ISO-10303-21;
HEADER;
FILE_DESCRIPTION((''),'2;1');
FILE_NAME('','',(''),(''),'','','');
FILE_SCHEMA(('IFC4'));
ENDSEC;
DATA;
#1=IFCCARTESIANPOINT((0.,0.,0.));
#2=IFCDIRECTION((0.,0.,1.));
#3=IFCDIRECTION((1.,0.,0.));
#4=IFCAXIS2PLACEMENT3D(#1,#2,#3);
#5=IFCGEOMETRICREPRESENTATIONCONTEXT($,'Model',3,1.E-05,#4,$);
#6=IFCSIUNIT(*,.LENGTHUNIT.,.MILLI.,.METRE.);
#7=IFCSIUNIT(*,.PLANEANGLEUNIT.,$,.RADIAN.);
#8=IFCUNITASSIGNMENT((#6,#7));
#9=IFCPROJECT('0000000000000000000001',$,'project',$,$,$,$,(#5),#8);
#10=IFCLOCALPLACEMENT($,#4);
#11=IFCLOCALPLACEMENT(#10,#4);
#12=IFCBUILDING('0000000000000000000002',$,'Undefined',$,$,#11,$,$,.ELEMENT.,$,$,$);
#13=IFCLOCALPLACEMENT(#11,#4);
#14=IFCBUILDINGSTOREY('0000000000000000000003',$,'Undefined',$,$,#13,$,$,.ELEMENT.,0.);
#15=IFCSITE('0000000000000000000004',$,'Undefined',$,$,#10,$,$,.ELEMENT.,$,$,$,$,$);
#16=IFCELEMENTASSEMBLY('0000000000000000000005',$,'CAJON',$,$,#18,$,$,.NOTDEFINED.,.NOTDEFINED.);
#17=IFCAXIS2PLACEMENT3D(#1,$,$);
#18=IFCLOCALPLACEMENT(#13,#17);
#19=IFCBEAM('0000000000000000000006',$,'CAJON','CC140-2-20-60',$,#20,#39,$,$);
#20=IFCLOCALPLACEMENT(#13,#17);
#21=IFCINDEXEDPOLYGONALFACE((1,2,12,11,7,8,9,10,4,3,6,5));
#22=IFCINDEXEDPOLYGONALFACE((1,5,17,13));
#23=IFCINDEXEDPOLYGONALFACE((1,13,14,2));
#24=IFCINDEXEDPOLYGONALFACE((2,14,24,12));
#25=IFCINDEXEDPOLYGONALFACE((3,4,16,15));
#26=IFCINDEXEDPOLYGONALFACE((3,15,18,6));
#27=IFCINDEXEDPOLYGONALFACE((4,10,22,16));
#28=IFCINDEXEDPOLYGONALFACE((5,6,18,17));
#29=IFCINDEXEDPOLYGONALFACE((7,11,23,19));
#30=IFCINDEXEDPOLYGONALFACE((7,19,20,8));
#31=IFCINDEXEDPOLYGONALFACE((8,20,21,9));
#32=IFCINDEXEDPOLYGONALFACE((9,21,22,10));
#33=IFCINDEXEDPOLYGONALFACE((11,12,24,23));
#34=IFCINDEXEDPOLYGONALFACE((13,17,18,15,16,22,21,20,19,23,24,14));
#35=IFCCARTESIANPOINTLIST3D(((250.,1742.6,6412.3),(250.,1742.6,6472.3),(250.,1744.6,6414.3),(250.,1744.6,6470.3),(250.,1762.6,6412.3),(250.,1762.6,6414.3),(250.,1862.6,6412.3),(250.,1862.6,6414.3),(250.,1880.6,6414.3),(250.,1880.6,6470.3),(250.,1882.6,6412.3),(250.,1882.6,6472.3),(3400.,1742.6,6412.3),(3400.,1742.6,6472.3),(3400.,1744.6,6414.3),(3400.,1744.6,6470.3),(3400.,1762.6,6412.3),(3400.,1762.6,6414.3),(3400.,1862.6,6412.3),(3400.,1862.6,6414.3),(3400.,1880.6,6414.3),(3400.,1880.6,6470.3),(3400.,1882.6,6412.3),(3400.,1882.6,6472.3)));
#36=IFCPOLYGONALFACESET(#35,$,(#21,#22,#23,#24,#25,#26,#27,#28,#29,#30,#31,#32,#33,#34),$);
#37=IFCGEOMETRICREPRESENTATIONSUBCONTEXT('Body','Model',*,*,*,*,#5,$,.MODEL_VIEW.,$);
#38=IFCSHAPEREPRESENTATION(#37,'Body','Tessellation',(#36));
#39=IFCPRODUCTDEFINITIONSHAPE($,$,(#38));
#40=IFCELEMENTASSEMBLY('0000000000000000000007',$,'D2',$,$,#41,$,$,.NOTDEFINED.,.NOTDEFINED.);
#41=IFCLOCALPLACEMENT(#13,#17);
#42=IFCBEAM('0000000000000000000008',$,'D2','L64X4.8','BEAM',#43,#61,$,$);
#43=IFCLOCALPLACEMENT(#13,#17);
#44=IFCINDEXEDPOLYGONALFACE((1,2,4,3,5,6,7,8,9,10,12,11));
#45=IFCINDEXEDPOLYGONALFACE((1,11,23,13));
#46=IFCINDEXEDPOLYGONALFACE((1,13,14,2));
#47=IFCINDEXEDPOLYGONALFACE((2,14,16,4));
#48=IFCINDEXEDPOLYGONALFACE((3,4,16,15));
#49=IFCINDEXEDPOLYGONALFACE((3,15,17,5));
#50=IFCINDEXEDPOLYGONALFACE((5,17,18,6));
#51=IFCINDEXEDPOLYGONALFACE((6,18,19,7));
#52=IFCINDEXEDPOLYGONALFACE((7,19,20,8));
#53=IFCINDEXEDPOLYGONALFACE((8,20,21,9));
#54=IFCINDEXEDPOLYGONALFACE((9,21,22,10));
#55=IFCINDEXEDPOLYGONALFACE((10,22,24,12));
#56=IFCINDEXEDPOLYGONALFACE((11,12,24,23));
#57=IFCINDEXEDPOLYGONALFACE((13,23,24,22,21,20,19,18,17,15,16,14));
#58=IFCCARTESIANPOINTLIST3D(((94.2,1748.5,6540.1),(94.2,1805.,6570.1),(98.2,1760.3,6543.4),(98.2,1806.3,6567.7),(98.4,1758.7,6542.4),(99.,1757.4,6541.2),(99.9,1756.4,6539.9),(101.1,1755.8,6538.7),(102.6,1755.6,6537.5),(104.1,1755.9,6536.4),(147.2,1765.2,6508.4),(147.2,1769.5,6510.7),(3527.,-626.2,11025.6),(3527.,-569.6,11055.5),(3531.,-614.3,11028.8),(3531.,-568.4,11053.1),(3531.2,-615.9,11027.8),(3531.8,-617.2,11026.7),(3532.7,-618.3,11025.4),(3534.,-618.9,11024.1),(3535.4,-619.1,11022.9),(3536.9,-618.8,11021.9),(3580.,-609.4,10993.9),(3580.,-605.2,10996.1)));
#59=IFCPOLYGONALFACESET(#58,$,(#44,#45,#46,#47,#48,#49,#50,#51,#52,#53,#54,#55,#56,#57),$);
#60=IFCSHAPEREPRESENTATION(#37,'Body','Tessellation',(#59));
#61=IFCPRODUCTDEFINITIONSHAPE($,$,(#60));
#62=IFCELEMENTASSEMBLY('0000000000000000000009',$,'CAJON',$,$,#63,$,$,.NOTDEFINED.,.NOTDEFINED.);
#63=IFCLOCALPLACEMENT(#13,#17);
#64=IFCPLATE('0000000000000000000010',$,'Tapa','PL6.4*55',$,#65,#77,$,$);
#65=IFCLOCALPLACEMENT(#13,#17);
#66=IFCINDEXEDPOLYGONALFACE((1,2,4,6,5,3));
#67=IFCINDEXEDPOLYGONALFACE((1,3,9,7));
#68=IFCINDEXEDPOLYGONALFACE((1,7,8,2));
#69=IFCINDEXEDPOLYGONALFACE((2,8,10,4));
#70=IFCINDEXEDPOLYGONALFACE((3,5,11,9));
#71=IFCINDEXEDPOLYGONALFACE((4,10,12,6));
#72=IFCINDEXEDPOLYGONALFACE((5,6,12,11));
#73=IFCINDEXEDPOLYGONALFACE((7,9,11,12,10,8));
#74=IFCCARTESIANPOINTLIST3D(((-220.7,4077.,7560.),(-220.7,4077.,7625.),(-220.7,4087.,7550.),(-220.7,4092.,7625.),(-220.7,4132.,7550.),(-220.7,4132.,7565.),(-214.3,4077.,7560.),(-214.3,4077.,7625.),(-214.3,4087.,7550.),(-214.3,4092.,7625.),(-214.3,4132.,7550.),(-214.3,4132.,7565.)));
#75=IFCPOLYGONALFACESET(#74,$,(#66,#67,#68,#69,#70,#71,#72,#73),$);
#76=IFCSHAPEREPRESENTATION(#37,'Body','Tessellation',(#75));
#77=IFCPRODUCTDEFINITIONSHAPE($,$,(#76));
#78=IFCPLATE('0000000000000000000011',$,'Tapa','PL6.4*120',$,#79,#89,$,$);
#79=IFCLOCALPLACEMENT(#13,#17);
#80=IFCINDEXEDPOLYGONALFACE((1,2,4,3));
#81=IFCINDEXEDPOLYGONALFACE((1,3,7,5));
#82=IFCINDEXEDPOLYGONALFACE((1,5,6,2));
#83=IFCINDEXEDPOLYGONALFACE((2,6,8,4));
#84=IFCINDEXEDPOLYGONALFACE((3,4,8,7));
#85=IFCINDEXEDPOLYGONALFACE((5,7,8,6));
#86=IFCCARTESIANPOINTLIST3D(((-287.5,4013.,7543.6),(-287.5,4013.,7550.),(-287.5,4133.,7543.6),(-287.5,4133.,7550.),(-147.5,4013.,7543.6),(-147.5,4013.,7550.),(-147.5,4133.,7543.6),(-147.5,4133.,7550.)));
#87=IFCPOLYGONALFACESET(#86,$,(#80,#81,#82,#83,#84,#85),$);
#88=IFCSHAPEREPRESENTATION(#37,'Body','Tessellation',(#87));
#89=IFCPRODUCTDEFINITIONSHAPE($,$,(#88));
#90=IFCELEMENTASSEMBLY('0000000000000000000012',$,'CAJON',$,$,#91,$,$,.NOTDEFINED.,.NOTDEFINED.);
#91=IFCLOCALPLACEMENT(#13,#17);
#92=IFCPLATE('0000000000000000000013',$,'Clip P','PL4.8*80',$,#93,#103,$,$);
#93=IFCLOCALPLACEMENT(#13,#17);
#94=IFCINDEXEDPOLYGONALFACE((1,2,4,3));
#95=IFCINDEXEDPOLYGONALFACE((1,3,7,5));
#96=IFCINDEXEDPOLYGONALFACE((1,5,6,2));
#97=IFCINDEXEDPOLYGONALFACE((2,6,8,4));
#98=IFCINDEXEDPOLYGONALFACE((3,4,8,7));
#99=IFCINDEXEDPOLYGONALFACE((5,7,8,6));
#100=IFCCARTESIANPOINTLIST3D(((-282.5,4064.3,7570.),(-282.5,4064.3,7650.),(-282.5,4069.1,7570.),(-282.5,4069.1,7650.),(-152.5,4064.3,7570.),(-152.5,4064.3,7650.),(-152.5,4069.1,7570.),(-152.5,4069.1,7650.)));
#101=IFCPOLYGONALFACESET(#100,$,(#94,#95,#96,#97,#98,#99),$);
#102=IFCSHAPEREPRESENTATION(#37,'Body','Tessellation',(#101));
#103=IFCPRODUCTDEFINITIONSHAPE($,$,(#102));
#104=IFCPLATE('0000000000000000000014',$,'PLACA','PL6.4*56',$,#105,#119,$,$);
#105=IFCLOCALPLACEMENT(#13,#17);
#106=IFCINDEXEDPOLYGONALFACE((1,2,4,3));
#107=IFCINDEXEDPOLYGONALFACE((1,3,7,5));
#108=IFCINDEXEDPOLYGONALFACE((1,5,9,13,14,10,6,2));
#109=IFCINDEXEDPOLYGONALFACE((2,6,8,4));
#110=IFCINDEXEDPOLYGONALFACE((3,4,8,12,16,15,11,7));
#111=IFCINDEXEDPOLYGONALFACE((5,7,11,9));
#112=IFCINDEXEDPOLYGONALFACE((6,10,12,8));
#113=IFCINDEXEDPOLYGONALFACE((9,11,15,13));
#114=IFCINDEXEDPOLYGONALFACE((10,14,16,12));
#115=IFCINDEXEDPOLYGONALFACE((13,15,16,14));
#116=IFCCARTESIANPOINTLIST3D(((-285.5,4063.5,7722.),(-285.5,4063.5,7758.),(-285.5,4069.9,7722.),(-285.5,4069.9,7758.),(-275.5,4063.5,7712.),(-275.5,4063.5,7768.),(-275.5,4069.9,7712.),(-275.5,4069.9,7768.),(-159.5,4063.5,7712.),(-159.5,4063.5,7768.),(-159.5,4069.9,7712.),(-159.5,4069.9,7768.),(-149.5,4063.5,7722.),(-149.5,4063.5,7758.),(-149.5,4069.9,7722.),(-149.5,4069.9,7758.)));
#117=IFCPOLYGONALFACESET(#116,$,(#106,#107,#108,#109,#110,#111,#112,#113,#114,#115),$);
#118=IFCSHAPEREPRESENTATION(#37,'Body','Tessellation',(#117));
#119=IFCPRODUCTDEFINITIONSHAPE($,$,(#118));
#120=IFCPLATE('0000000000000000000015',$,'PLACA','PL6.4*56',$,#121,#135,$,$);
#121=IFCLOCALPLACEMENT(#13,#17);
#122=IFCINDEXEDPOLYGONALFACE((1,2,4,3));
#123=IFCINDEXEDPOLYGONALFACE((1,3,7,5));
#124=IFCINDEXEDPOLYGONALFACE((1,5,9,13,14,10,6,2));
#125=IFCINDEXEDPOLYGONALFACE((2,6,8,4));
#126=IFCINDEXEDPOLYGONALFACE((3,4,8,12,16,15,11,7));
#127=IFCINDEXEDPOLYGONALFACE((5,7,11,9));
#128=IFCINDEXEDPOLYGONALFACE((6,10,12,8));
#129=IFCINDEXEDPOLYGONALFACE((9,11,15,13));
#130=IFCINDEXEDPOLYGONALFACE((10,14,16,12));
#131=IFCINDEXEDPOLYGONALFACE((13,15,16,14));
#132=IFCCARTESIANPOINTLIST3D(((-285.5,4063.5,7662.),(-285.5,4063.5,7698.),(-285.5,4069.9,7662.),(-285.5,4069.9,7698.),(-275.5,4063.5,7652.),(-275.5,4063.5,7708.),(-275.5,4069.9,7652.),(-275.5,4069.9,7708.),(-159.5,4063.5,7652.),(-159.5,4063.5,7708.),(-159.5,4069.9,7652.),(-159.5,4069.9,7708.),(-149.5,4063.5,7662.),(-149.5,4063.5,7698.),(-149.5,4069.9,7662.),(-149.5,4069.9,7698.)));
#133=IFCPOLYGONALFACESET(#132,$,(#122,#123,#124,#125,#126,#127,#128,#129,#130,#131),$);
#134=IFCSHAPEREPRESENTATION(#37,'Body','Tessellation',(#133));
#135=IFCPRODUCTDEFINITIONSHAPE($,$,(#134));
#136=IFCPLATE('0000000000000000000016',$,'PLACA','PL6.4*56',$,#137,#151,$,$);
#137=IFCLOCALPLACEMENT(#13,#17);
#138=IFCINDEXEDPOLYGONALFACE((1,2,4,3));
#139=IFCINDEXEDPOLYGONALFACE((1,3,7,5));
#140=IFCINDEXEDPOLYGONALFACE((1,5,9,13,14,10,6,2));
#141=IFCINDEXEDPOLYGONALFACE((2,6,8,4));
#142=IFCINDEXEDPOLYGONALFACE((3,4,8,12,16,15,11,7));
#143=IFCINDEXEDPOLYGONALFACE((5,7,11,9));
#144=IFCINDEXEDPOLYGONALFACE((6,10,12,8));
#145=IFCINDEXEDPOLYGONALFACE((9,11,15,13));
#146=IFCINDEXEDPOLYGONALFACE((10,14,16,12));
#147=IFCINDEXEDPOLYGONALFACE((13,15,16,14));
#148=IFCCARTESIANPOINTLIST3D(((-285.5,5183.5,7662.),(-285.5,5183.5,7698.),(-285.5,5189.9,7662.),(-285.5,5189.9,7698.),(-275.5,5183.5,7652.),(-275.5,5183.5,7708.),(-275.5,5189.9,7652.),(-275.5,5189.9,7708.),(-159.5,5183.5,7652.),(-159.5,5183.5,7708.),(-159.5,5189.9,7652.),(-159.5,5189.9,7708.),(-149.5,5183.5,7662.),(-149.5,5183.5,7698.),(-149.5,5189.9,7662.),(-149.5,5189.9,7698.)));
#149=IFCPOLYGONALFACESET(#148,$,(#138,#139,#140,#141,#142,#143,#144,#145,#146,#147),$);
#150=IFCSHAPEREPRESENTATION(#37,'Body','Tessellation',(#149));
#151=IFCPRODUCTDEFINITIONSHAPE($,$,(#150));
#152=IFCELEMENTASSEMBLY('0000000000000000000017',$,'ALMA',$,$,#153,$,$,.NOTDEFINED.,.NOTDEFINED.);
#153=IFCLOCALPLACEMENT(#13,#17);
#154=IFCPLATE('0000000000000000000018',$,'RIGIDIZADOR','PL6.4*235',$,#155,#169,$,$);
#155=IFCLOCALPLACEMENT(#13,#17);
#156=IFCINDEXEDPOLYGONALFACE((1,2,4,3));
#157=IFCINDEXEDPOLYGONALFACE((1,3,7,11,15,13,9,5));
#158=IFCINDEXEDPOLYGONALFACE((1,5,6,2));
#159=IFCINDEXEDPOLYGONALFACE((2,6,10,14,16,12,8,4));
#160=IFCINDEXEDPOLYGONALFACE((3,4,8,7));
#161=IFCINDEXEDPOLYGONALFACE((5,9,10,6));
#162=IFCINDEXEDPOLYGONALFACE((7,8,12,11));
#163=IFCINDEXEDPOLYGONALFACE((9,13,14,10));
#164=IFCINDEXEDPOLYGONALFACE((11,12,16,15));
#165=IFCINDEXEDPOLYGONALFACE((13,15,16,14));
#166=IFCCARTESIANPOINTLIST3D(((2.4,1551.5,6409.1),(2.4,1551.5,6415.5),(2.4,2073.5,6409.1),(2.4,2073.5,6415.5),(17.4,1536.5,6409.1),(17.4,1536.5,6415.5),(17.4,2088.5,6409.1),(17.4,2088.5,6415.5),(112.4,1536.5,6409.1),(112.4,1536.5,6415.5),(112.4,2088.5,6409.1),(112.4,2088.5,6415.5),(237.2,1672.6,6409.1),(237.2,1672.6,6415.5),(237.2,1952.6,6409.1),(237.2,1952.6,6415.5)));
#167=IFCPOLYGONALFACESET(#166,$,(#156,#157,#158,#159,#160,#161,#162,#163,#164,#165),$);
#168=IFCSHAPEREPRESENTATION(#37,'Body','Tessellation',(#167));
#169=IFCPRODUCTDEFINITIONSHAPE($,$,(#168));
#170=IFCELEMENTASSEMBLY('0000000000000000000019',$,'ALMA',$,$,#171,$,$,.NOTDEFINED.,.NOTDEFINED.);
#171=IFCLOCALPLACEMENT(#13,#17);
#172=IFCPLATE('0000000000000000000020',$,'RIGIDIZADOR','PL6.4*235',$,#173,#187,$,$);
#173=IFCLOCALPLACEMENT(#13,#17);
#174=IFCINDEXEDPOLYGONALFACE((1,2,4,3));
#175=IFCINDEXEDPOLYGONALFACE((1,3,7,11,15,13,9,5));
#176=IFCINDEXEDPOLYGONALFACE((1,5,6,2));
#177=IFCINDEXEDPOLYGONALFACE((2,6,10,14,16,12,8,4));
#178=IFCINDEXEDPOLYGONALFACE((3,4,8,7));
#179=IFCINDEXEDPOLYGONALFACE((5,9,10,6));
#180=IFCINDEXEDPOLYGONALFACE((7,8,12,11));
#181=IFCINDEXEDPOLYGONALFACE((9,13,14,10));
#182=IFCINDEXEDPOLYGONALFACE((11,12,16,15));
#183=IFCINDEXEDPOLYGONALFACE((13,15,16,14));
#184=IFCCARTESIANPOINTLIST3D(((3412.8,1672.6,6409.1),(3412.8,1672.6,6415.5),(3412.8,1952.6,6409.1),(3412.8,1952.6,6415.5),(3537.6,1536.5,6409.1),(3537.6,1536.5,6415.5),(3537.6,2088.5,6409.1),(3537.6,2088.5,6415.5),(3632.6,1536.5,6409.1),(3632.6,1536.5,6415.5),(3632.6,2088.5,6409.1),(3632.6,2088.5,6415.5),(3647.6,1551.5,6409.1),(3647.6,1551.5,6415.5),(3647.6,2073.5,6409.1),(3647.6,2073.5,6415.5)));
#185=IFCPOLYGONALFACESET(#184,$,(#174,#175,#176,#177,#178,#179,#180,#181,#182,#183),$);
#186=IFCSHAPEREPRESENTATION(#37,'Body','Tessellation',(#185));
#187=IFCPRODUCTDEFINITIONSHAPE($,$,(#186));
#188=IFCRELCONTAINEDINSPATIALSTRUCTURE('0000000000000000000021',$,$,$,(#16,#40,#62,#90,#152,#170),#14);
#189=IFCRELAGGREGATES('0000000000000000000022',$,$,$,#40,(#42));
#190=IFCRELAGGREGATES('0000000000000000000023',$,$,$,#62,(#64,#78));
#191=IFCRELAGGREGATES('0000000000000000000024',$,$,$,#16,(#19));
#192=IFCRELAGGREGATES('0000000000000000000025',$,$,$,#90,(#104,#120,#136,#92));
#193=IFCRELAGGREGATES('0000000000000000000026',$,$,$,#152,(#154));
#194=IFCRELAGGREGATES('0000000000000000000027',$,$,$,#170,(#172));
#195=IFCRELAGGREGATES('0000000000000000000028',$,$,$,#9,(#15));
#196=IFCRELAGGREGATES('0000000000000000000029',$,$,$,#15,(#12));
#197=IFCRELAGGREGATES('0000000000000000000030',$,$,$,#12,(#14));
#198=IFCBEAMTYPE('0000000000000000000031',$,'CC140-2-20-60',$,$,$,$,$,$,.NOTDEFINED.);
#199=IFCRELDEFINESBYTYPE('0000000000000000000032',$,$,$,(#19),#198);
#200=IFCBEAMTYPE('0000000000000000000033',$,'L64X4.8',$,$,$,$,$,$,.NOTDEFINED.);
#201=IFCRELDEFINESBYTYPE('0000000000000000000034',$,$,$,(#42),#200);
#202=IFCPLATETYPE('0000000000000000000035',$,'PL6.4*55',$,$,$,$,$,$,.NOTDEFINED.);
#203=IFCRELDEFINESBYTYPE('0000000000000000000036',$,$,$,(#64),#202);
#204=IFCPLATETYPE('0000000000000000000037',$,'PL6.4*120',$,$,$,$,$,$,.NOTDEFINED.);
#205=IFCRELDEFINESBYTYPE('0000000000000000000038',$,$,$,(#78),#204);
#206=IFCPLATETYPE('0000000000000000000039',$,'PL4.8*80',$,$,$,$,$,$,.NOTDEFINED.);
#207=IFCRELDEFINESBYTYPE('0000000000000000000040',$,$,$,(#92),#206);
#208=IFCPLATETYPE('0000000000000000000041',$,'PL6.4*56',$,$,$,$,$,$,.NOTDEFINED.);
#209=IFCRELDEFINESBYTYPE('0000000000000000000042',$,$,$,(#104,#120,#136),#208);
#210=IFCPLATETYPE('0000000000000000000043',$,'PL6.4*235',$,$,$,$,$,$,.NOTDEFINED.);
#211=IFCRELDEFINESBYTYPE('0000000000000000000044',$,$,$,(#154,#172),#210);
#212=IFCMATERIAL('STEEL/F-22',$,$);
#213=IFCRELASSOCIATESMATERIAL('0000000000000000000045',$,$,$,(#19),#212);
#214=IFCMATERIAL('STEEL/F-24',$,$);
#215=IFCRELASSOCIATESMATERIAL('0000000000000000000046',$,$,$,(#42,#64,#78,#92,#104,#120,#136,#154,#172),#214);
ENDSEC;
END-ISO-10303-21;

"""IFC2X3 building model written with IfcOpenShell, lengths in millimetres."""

from ifc_helpers import new_model, si_unit, frame, origin_with_axes, origin_2d_with_axis, place, context, subcontext, project, spatial, polyline, l_section, c_section, outline, extrude, material, type_object, element, aggregate, save


model = new_model("IFC2X3")

# Units and contexts
model_context = context("Model", 3, precision=1e-05, world=origin_with_axes())
body_context = subcontext(model_context, "Body", "Model", "MODEL_VIEW")
ifc_project = project(units=[si_unit("LENGTHUNIT", "METRE", prefix="MILLI"), si_unit("PLANEANGLEUNIT", "RADIAN")], contexts=[model_context])

# Site, building, storey
site_placement = place(None, origin_with_axes())
site = spatial("IfcSite", under=ifc_project, at=site_placement, Name="Undefined", CompositionType="ELEMENT")
building_placement = place(site_placement, origin_with_axes())
building = spatial("IfcBuilding", under=site, at=building_placement, Name="Undefined", CompositionType="ELEMENT")
storey_placement = place(building_placement, origin_with_axes())
storey = spatial("IfcBuildingStorey", under=building, at=storey_placement, Name="Undefined", CompositionType="ELEMENT", Elevation=0.0)

# Element assemblies, beams
assembly_1_placement = place(storey_placement, origin_with_axes())
assembly_1 = element("IfcElementAssembly", 1, at=assembly_1_placement, inside=storey, Name="CAJON", AssemblyPlace="NOTDEFINED", PredefinedType="NOTDEFINED")
ifc_material_1 = material(Name="STEEL/F-22")
beam_type_1 = type_object("IfcBeamType", Name="CC140-2-20-60", PredefinedType="NOTDEFINED")
beam_1_placement = place(assembly_1_placement, frame((3400.0, 1812.6, 6442.3), z_axis=(0.000003, 1.0, 0.0), x_axis=(-1.0, 0.000003, 0.0)))
beam_1 = element("IfcBeam", 2, at=beam_1_placement, type_object=beam_type_1, material=ifc_material_1, Name="CAJON", Description="CC140-2-20-60", context=body_context, shape_type="SweptSolid", body=[
    extrude(c_section(Depth=140.0, Width=60.0, WallThickness=2.0, Girth=20.0, at=origin_2d_with_axis()), frame((3150.0, 0.0, 0.0), z_axis=(-1.0, 0.0, 0.0), x_axis=(0.0, -1.0, 0.0)), (0.0, 0.0, 1.0), 3150.0),
])
assembly_2_placement = place(storey_placement, origin_with_axes())
assembly_2 = element("IfcElementAssembly", 3, at=assembly_2_placement, inside=storey, Name="D2", AssemblyPlace="NOTDEFINED", PredefinedType="NOTDEFINED")
ifc_material_2 = material(Name="STEEL/F-24")
beam_type_2 = type_object("IfcBeamType", Name="L64X4.8", PredefinedType="NOTDEFINED")
beam_2_placement = place(assembly_2_placement, frame((120.7, 1785.1, 6539.3), z_axis=(0.828317, 0.262139, -0.495151), x_axis=(0.56026, -0.387559, 0.732056)))
beam_2 = element("IfcBeam", 4, at=beam_2_placement, type_object=beam_type_2, material=ifc_material_2, Name="D2", Description="L64X4.8", ObjectType="BEAM", context=body_context, shape_type="SweptSolid", body=[
    extrude(l_section(Depth=64.0, Width=64.0, Thickness=4.8, FilletRadius=7.2, at=origin_2d_with_axis()), frame((6127.2, 0.0, 0.0), z_axis=(-1.0, 0.0, 0.0), x_axis=(0.0, -1.0, 0.0)), (0.0, 0.0, 1.0), 6127.2),
])
aggregate(assembly_2, [beam_2])

# Element assemblies, plates
assembly_3_placement = place(storey_placement, origin_with_axes())
assembly_3 = element("IfcElementAssembly", 5, at=assembly_3_placement, inside=storey, Name="CAJON", AssemblyPlace="NOTDEFINED", PredefinedType="NOTDEFINED")
plate_type_1 = type_object("IfcPlateType", Name="PL6.4*55", PredefinedType="NOTDEFINED")
plate_1_placement = place(assembly_3_placement, frame((-217.5, 4077.0, 7625.0), z_axis=(1.0, 0.0, 0.0), x_axis=(0.0, -0.000064, -1.0)))
plate_1 = element("IfcPlate", 6, at=plate_1_placement, type_object=plate_type_1, material=ifc_material_2, Name="Tapa", Description="PL6.4*55", context=body_context, shape_type="SweptSolid", body=[
    extrude(outline(polyline([(0.0, 0.0), (65.0, 0.0), (75.0, 10.0), (75.0, 55.0), (60.0, 55.0), (0.0, 15.0), (0.0, 0.0)])), frame((0.0, 0.0, -3.2), z_axis=(0.0, 0.0, 1.0), x_axis=(1.0, 0.0, 0.0)), (0.0, 0.0, 1.0), 6.4),
])
plate_type_2 = type_object("IfcPlateType", Name="PL6.4*120", PredefinedType="NOTDEFINED")
plate_2_placement = place(assembly_3_placement, frame((-287.5, 4133.0, 7546.8), z_axis=(0.0, 0.000039, 1.0), x_axis=(0.0, -1.0, 0.000039)))
plate_2 = element("IfcPlate", 7, at=plate_2_placement, type_object=plate_type_2, material=ifc_material_2, Name="Tapa", Description="PL6.4*120", context=body_context, shape_type="SweptSolid", body=[
    extrude(outline(polyline([(0.0, 0.0), (120.0, 0.0), (120.0, 140.0), (0.0, 140.0), (0.0, 0.0)])), frame((0.0, 0.0, -3.2), z_axis=(0.0, 0.0, 1.0), x_axis=(1.0, 0.0, 0.0)), (0.0, 0.0, 1.0), 6.4),
])
aggregate(assembly_3, [plate_1, plate_2])
assembly_4_placement = place(storey_placement, origin_with_axes())
assembly_4 = element("IfcElementAssembly", 8, at=assembly_4_placement, inside=storey, Name="CAJON", AssemblyPlace="NOTDEFINED", PredefinedType="NOTDEFINED")
plate_type_3 = type_object("IfcPlateType", Name="PL4.8*80", PredefinedType="NOTDEFINED")
plate_3_placement = place(assembly_4_placement, frame((-152.5, 4066.7, 7570.0), z_axis=(0.0, 1.0, -0.000052), x_axis=(-1.0, 0.0, 0.0)))
plate_3 = element("IfcPlate", 9, at=plate_3_placement, type_object=plate_type_3, material=ifc_material_2, Name="Clip P", Description="PL4.8*80", context=body_context, shape_type="SweptSolid", body=[
    extrude(outline(polyline([(0.0, 0.0), (130.0, 0.0), (130.0, 80.0), (0.0, 80.0), (0.0, 0.0)])), frame((0.0, 0.0, -2.4), z_axis=(0.0, 0.0, 1.0), x_axis=(1.0, 0.0, 0.0)), (0.0, 0.0, 1.0), 4.8),
])
plate_type_4 = type_object("IfcPlateType", Name="PL6.4*56", PredefinedType="NOTDEFINED")
plate_4_placement = place(assembly_4_placement, frame((-149.5, 4066.7, 7712.0), z_axis=(0.0, -1.0, 0.000004), x_axis=(0.0, 0.000004, 1.0)))
plate_4 = element("IfcPlate", 10, at=plate_4_placement, type_object=plate_type_4, material=ifc_material_2, Name="PLACA", Description="PL6.4*56", context=body_context, shape_type="SweptSolid", body=[
    extrude(outline(polyline([(0.0, 10.0), (10.0, 0.0), (46.0, 0.0), (56.0, 10.0), (56.0, 126.0), (46.0, 136.0), (10.0, 136.0), (0.0, 126.0), (0.0, 10.0)])), frame((0.0, 0.0, -3.2), z_axis=(0.0, 0.0, 1.0), x_axis=(1.0, 0.0, 0.0)), (0.0, 0.0, 1.0), 6.4),
])
plate_5_placement = place(assembly_4_placement, frame((-149.5, 4066.7, 7708.0), z_axis=(0.0, 1.0, -0.000004), x_axis=(0.0, -0.000004, -1.0)))
plate_5 = element("IfcPlate", 11, at=plate_5_placement, type_object=plate_type_4, material=ifc_material_2, Name="PLACA", Description="PL6.4*56", context=body_context, shape_type="SweptSolid", body=[
    extrude(outline(polyline([(0.0, 10.0), (10.0, 0.0), (46.0, 0.0), (56.0, 10.0), (56.0, 126.0), (46.0, 136.0), (10.0, 136.0), (0.0, 126.0), (0.0, 10.0)])), frame((0.0, 0.0, -3.2), z_axis=(0.0, 0.0, 1.0), x_axis=(1.0, 0.0, 0.0)), (0.0, 0.0, 1.0), 6.4),
])
plate_6_placement = place(assembly_4_placement, frame((-149.5, 5186.7, 7708.0), z_axis=(0.0, 1.0, -0.000004), x_axis=(0.0, -0.000004, -1.0)))
plate_6 = element("IfcPlate", 12, at=plate_6_placement, type_object=plate_type_4, material=ifc_material_2, Name="PLACA", Description="PL6.4*56", context=body_context, shape_type="SweptSolid", body=[
    extrude(outline(polyline([(0.0, 10.0), (10.0, 0.0), (46.0, 0.0), (56.0, 10.0), (56.0, 126.0), (46.0, 136.0), (10.0, 136.0), (0.0, 126.0), (0.0, 10.0)])), frame((0.0, 0.0, -3.2), z_axis=(0.0, 0.0, 1.0), x_axis=(1.0, 0.0, 0.0)), (0.0, 0.0, 1.0), 6.4),
])

# Element assembly, plate
assembly_5_placement = place(storey_placement, origin_with_axes())
assembly_5 = element("IfcElementAssembly", 13, at=assembly_5_placement, inside=storey, Name="ALMA", AssemblyPlace="NOTDEFINED", PredefinedType="NOTDEFINED")
plate_type_5 = type_object("IfcPlateType", Name="PL6.4*235", PredefinedType="NOTDEFINED")
plate_7_placement = place(assembly_5_placement, frame((112.4, 2088.5, 6412.3), z_axis=(0.0, 0.0, 1.0), x_axis=(-1.0, 0.0, 0.0)))
plate_7 = element("IfcPlate", 14, at=plate_7_placement, type_object=plate_type_5, material=ifc_material_2, Name="RIGIDIZADOR", Description="PL6.4*235", context=body_context, shape_type="SweptSolid", body=[
    extrude(outline(polyline([(0.0, 0.0), (95.0, 0.0), (110.0, 15.0), (110.0, 537.0), (95.0, 552.0), (0.0, 552.0), (-124.8, 415.9), (-124.8, 135.9), (0.0, 0.0)])), frame((0.0, 0.0, -3.2), z_axis=(0.0, 0.0, 1.0), x_axis=(1.0, 0.0, 0.0)), (0.0, 0.0, 1.0), 6.4),
])

# Element assembly, plate
assembly_6_placement = place(storey_placement, origin_with_axes())
assembly_6 = element("IfcElementAssembly", 15, at=assembly_6_placement, inside=storey, Name="ALMA", AssemblyPlace="NOTDEFINED", PredefinedType="NOTDEFINED")
plate_8_placement = place(assembly_6_placement, frame((3537.6, 2088.5, 6412.3), z_axis=(0.0, 0.0, -1.0), x_axis=(1.0, 0.0, 0.0)))
plate_8 = element("IfcPlate", 16, at=plate_8_placement, type_object=plate_type_5, material=ifc_material_2, Name="RIGIDIZADOR", Description="PL6.4*235", context=body_context, shape_type="SweptSolid", body=[
    extrude(outline(polyline([(0.0, 0.0), (95.0, 0.0), (110.0, 15.0), (110.0, 537.0), (95.0, 552.0), (0.0, 552.0), (-124.8, 415.9), (-124.8, 135.9), (0.0, 0.0)])), frame((0.0, 0.0, -3.2), z_axis=(0.0, 0.0, 1.0), x_axis=(1.0, 0.0, 0.0)), (0.0, 0.0, 1.0), 6.4),
])

aggregate(assembly_1, [beam_1])

aggregate(assembly_4, [plate_4, plate_5, plate_6, plate_3])
aggregate(assembly_5, [plate_7])
aggregate(assembly_6, [plate_8])

save(model, "model.ifc")
